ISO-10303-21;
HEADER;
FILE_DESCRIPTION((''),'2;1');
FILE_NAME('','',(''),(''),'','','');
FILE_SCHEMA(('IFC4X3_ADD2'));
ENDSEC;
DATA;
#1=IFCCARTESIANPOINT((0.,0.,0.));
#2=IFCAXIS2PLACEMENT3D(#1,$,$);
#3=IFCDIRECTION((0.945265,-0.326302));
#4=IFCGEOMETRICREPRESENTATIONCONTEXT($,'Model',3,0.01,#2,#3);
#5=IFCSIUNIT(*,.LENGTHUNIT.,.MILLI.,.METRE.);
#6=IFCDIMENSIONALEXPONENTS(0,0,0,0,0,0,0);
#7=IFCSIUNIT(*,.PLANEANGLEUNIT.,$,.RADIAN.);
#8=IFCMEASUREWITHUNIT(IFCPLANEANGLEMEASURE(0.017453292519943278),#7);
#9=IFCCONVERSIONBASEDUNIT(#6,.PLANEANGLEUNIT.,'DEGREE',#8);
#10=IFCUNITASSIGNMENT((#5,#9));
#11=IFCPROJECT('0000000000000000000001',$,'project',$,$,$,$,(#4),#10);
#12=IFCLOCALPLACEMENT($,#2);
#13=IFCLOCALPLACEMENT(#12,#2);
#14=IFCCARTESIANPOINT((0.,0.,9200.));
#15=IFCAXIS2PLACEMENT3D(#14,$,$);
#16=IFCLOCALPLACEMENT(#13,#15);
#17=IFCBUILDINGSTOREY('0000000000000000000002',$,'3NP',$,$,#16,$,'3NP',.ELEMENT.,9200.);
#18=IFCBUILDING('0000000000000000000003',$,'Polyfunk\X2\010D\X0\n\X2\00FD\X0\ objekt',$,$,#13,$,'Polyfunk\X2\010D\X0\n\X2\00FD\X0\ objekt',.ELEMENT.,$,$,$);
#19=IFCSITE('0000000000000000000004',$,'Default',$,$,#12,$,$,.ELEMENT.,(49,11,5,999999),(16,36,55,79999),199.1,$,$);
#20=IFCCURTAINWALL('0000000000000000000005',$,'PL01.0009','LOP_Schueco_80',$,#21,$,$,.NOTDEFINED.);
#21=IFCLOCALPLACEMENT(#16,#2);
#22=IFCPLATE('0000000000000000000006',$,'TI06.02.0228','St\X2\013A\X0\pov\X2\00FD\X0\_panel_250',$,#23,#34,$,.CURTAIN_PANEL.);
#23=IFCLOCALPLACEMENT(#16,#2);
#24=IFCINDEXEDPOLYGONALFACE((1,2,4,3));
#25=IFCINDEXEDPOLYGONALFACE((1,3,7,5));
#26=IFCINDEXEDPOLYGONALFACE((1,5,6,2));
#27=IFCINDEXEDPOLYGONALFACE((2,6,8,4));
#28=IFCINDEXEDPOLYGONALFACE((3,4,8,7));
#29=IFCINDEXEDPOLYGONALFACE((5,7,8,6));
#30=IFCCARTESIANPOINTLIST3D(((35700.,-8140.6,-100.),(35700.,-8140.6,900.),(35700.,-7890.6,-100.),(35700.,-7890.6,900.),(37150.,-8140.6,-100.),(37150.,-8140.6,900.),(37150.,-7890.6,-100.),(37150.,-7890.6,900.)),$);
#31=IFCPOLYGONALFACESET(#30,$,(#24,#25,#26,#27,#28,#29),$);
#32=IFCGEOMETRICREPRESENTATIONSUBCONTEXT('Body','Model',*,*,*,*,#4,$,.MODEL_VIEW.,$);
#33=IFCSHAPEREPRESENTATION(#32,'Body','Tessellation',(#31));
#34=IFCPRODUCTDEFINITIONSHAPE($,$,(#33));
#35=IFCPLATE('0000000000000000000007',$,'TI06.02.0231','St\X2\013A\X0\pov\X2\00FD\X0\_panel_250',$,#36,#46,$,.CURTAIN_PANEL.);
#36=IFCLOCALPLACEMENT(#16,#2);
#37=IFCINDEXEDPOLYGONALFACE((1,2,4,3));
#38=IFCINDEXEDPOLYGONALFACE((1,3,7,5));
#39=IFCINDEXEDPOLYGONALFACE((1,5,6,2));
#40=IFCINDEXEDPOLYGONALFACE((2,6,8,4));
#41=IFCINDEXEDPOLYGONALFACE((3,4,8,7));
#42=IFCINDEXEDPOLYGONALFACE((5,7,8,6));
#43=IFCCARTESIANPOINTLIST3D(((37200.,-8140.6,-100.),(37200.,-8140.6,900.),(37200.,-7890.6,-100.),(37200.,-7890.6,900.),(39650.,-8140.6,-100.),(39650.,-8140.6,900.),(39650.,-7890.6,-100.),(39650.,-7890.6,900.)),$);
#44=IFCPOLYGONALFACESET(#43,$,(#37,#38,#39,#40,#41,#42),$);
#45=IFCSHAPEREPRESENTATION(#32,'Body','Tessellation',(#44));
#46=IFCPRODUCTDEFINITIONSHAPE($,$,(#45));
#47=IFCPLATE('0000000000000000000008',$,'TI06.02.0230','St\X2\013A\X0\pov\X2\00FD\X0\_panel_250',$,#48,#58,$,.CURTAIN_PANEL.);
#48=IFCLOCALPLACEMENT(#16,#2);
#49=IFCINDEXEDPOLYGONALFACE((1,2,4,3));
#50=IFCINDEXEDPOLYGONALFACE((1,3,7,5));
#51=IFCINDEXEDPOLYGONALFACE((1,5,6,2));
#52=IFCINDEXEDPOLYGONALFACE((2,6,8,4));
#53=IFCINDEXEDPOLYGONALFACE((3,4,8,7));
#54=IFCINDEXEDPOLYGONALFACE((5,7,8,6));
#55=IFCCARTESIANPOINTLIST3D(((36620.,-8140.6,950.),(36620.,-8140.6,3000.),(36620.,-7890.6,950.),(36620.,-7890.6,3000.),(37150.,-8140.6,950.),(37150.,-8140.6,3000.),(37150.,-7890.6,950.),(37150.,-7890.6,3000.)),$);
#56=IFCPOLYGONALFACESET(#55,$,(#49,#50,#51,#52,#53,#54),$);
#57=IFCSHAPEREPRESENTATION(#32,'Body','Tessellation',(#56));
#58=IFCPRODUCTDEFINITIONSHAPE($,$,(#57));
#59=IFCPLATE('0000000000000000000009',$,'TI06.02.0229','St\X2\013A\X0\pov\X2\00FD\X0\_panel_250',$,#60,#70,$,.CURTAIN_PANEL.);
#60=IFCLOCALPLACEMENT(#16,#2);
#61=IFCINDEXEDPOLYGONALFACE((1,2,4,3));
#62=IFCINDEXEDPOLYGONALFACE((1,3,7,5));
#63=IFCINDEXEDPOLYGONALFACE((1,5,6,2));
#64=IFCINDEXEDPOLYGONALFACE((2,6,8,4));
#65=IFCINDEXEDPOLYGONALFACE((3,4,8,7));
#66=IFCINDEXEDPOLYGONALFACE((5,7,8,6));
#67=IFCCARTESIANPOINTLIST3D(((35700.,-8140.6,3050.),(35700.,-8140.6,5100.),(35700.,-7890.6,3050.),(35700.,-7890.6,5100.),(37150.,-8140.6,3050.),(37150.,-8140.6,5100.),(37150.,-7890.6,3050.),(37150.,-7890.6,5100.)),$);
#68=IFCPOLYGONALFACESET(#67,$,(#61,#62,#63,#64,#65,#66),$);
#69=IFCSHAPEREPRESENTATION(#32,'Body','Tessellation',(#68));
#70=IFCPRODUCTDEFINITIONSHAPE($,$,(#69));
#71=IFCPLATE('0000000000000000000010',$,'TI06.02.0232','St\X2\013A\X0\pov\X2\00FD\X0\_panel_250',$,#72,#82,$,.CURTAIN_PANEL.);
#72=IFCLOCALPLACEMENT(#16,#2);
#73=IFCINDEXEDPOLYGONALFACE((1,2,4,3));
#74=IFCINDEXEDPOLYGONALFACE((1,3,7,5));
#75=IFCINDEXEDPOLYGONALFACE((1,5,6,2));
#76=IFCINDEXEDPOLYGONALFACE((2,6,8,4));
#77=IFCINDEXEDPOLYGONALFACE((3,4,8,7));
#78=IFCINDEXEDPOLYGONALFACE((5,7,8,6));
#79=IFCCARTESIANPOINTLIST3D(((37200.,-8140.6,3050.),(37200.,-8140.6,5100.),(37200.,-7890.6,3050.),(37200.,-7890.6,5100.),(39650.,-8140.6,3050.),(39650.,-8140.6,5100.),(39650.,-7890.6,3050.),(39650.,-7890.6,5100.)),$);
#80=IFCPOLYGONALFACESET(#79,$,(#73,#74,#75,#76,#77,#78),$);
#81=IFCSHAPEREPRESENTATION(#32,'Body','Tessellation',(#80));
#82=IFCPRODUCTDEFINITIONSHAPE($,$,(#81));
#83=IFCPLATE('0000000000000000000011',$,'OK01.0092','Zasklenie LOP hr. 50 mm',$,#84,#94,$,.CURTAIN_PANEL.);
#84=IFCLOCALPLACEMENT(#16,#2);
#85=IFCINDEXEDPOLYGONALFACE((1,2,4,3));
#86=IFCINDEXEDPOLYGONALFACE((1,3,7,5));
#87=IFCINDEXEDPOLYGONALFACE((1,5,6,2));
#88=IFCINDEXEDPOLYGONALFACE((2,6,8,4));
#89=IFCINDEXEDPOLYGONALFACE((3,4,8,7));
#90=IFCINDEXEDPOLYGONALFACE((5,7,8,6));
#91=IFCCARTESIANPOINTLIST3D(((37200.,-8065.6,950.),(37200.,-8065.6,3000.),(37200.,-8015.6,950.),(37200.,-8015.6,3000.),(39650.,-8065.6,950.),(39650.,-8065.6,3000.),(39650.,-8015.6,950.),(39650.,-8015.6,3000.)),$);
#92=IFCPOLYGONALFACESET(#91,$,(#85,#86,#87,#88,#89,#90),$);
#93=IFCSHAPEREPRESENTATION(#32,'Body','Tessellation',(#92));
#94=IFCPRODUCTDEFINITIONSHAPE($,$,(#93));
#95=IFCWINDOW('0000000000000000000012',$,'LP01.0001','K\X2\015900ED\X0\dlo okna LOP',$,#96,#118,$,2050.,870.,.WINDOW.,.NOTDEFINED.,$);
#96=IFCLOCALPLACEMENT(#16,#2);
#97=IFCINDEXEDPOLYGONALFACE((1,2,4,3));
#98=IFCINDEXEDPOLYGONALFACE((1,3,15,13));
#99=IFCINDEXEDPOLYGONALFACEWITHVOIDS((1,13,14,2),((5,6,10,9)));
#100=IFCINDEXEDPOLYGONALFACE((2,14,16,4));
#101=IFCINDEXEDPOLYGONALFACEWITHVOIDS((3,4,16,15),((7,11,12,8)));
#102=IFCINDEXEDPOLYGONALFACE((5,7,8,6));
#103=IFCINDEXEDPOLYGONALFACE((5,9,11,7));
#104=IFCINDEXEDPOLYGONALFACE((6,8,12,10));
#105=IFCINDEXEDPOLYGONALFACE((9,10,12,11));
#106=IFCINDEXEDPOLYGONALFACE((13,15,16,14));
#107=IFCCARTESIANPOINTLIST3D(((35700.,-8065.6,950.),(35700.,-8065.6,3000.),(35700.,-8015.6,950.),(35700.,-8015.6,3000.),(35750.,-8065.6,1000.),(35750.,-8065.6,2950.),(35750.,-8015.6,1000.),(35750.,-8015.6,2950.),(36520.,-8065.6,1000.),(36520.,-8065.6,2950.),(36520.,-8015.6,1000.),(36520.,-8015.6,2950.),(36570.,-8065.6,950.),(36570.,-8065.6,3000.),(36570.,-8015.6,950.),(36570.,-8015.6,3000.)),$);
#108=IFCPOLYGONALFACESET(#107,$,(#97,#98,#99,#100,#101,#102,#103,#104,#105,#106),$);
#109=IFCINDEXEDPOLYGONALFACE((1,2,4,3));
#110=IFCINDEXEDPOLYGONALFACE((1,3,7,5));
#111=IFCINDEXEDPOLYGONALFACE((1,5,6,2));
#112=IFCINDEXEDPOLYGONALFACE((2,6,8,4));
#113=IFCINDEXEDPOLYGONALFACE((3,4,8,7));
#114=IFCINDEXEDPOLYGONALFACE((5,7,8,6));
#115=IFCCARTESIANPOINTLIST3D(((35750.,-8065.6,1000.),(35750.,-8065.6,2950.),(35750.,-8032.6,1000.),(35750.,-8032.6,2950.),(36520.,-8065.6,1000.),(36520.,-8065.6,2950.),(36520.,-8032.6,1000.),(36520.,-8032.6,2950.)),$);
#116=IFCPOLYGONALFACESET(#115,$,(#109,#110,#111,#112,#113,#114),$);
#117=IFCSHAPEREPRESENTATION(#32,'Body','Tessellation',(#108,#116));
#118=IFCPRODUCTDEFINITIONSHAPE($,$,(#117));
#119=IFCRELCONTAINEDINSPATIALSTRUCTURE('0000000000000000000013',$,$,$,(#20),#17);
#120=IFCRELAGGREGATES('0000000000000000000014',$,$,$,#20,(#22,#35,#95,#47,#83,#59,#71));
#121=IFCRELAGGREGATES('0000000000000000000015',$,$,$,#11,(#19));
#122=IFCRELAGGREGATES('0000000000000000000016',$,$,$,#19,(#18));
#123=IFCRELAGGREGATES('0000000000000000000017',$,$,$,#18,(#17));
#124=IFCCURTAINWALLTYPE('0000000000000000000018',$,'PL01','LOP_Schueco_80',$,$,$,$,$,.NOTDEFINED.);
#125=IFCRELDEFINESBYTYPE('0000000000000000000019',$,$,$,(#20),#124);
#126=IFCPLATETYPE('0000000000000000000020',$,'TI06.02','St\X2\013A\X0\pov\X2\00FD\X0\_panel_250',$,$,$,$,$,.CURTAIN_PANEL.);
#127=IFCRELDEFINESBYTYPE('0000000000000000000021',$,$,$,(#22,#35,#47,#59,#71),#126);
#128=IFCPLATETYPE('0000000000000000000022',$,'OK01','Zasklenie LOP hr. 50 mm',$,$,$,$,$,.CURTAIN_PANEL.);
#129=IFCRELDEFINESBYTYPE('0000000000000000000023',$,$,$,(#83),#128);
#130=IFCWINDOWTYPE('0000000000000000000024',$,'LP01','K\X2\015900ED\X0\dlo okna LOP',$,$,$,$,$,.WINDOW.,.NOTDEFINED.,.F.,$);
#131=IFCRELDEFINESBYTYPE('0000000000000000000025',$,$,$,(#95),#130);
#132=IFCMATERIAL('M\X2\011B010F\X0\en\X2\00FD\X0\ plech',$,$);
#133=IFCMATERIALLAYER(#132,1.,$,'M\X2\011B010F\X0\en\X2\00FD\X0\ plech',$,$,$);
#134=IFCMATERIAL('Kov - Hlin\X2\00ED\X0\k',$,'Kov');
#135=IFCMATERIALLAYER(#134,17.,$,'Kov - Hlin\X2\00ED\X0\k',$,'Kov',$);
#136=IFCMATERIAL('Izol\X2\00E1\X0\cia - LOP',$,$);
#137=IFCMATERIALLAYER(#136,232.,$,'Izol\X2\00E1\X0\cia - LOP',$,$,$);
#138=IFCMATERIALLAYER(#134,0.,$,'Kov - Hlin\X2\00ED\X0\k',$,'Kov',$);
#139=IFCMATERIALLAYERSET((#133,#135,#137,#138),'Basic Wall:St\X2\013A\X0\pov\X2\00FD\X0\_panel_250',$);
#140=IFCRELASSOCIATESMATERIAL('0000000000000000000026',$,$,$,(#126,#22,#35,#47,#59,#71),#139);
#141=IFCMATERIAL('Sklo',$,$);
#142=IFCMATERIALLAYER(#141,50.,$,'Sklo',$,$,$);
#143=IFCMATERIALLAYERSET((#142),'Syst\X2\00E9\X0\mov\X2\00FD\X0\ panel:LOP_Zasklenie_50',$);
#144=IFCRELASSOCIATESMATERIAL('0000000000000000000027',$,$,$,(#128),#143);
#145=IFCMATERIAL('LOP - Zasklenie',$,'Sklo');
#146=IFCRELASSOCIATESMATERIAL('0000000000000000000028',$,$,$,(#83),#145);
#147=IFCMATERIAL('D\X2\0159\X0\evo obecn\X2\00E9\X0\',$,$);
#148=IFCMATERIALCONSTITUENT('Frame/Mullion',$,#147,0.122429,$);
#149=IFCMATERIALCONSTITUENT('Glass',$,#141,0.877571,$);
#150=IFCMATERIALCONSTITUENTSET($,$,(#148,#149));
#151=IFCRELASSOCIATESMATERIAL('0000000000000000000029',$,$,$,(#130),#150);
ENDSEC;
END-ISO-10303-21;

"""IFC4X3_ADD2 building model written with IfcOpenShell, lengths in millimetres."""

from ifc_helpers import new_model, entity, si_unit, converted_unit, direction, frame, frame_2d, origin, origin_2d_with_axis, place, context, subcontext, project, spatial, polyline, rectangle, outline, extrude, source, transform, mapped, material, layer, layer_set, layer_usage, constituent, constituent_set, type_object, type_shapes, element, aggregate, save


model = new_model("IFC4X3_ADD2")

# Units and contexts
model_context = context("Model", 3, precision=0.01, world=origin(), true_north=direction((0.945265, -0.326302)))
body_context = subcontext(model_context, "Body", "Model", "MODEL_VIEW")
ifc_project = project(units=[si_unit("LENGTHUNIT", "METRE", prefix="MILLI"), converted_unit("PLANEANGLEUNIT", "DEGREE", entity("IfcPlaneAngleMeasure", 0.017453292519943278), si_unit("PLANEANGLEUNIT", "RADIAN"), dimensions=[0, 0, 0, 0, 0, 0, 0])], contexts=[model_context])

# Site, building, storey
site_placement = place(None, origin())
site = spatial("IfcSite", under=ifc_project, at=site_placement, Name="Default", CompositionType="ELEMENT", RefLatitude=(49, 11, 5, 999999), RefLongitude=(16, 36, 55, 79999), RefElevation=199.1)
building_placement = place(site_placement, origin())
building = spatial("IfcBuilding", under=site, at=building_placement, Name="Polyfunkčný objekt", LongName="Polyfunkčný objekt", CompositionType="ELEMENT")
storey_placement = place(building_placement, frame((0.0, 0.0, 9200.0)))
storey = spatial("IfcBuildingStorey", under=building, at=storey_placement, Name="3NP", LongName="3NP", CompositionType="ELEMENT", Elevation=9200.0)

# Curtain wall, plates, window
curtain_wall_type = type_object("IfcCurtainWallType", Name="PL01", Description="LOP_Schueco_80", PredefinedType="NOTDEFINED")
curtain_wall_placement = place(storey_placement, frame((0.0, 0.0, -9200.0)))
curtain_wall = element("IfcCurtainWall", 1, at=curtain_wall_placement, inside=storey, type_object=curtain_wall_type, Name="PL01.0009", Description="LOP_Schueco_80", PredefinedType="NOTDEFINED")
ifc_material_1 = material(Name="Měďený plech")
ifc_layer_1 = layer(ifc_material_1, 1.0, Name="Měďený plech")
ifc_material_2 = material(Name="Kov - Hliník", Category="Kov")
ifc_layer_2 = layer(ifc_material_2, 17.0, Name="Kov - Hliník", Category="Kov")
ifc_material_3 = material(Name="Izolácia - LOP")
ifc_layer_3 = layer(ifc_material_3, 232.0, Name="Izolácia - LOP")
ifc_layer_4 = layer(ifc_material_2, 0.0, Name="Kov - Hliník", Category="Kov")
ifc_layer_set_1 = layer_set([ifc_layer_1, ifc_layer_2, ifc_layer_3, ifc_layer_4], Name="Basic Wall:Stĺpový_panel_250")
ifc_layer_usage_1 = layer_usage(ifc_layer_set_1, "AXIS2", "POSITIVE", -125.0)
plate_type_1 = type_object("IfcPlateType", Name="TI06.02", Description="Stĺpový_panel_250", PredefinedType="CURTAIN_PANEL", material=ifc_layer_set_1)
plate_1_placement = place(storey_placement, frame((35700.0, -8015.6, -100.0)))
plate_1 = element("IfcPlate", 2, at=plate_1_placement, type_object=plate_type_1, material=ifc_layer_usage_1, Name="TI06.02.0228", Description="Stĺpový_panel_250", PredefinedType="CURTAIN_PANEL", context=body_context, shape_type="SweptSolid", body=[
    extrude(rectangle(XDim=250.0, YDim=1450.0, at=frame_2d((0.0, 0.0), x_axis=(1.0, 0.0))), frame((725.0, 0.0, 0.0), z_axis=(0.0, 0.0, 1.0), x_axis=(0.0, 1.0, 0.0)), (0.0, 0.0, 1.0), 1000.0),
])
ifc_layer_usage_2 = layer_usage(ifc_layer_set_1, "AXIS2", "POSITIVE", -125.0)
plate_2_placement = place(storey_placement, frame((37200.0, -8015.6, -100.0)))
plate_2 = element("IfcPlate", 3, at=plate_2_placement, type_object=plate_type_1, material=ifc_layer_usage_2, Name="TI06.02.0231", Description="Stĺpový_panel_250", PredefinedType="CURTAIN_PANEL", context=body_context, shape_type="SweptSolid", body=[
    extrude(rectangle(XDim=250.0, YDim=2450.0, at=frame_2d((0.0, 0.0), x_axis=(1.0, 0.0))), frame((1225.0, 0.0, 0.0), z_axis=(0.0, 0.0, 1.0), x_axis=(0.0, 1.0, 0.0)), (0.0, 0.0, 1.0), 1000.0),
])
ifc_layer_usage_3 = layer_usage(ifc_layer_set_1, "AXIS2", "POSITIVE", -125.0)
plate_3_placement = place(storey_placement, frame((36620.0, -8015.6, 950.0)))
plate_3 = element("IfcPlate", 4, at=plate_3_placement, type_object=plate_type_1, material=ifc_layer_usage_3, Name="TI06.02.0230", Description="Stĺpový_panel_250", PredefinedType="CURTAIN_PANEL", context=body_context, shape_type="SweptSolid", body=[
    extrude(rectangle(XDim=250.0, YDim=530.0, at=frame_2d((0.0, 0.0), x_axis=(1.0, 0.0))), frame((265.0, 0.0, 0.0), z_axis=(0.0, 0.0, 1.0), x_axis=(0.0, 1.0, 0.0)), (0.0, 0.0, 1.0), 2050.0),
])
ifc_layer_usage_4 = layer_usage(ifc_layer_set_1, "AXIS2", "POSITIVE", -125.0)
plate_4_placement = place(storey_placement, frame((35700.0, -8015.6, 3050.0)))
plate_4 = element("IfcPlate", 5, at=plate_4_placement, type_object=plate_type_1, material=ifc_layer_usage_4, Name="TI06.02.0229", Description="Stĺpový_panel_250", PredefinedType="CURTAIN_PANEL", context=body_context, shape_type="SweptSolid", body=[
    extrude(rectangle(XDim=250.0, YDim=1450.0, at=frame_2d((0.0, 0.0), x_axis=(1.0, 0.0))), frame((725.0, 0.0, 0.0), z_axis=(0.0, 0.0, 1.0), x_axis=(0.0, 1.0, 0.0)), (0.0, 0.0, 1.0), 2050.0),
])
ifc_layer_usage_5 = layer_usage(ifc_layer_set_1, "AXIS2", "POSITIVE", -125.0)
plate_5_placement = place(storey_placement, frame((37200.0, -8015.6, 3050.0)))
plate_5 = element("IfcPlate", 6, at=plate_5_placement, type_object=plate_type_1, material=ifc_layer_usage_5, Name="TI06.02.0232", Description="Stĺpový_panel_250", PredefinedType="CURTAIN_PANEL", context=body_context, shape_type="SweptSolid", body=[
    extrude(rectangle(XDim=250.0, YDim=2450.0, at=frame_2d((0.0, 0.0), x_axis=(1.0, 0.0))), frame((1225.0, 0.0, 0.0), z_axis=(0.0, 0.0, 1.0), x_axis=(0.0, 1.0, 0.0)), (0.0, 0.0, 1.0), 2050.0),
])
ifc_material_4 = material(Name="LOP - Zasklenie", Category="Sklo")
ifc_material_5 = material(Name="Sklo")
ifc_layer_5 = layer(ifc_material_5, 50.0, Name="Sklo")
ifc_layer_set_2 = layer_set([ifc_layer_5], Name="Systémový panel:LOP_Zasklenie_50")
plate_type_2 = type_object("IfcPlateType", Name="OK01", Description="Zasklenie LOP hr. 50 mm", PredefinedType="CURTAIN_PANEL", material=ifc_layer_set_2)
shared_shape_1 = source(origin(), body_context, "Body", "SweptSolid", [
    extrude(rectangle(XDim=50.0, YDim=2450.0, at=origin_2d_with_axis()), frame((0.0, -25.0, 0.0), z_axis=(0.0, 0.0, 1.0), x_axis=(0.0, 1.0, 0.0)), (0.0, 0.0, 1.0), 2050.0),
])
type_shapes(plate_type_2, [shared_shape_1])
plate_6_placement = place(curtain_wall_placement, frame((38425.0, -8015.6, 10150.0)))
plate_6 = element("IfcPlate", 7, at=plate_6_placement, type_object=plate_type_2, material=ifc_material_4, Name="OK01.0092", Description="Zasklenie LOP hr. 50 mm", PredefinedType="CURTAIN_PANEL", context=body_context, shape_type="MappedRepresentation", body=[
    mapped(shared_shape_1, transform((0.0, 0.0, 0.0), scale=1.0)),
])
ifc_material_6 = material(Name="Dřevo obecné")
ifc_constituent_1 = constituent(ifc_material_6, Name="Frame/Mullion", fraction=0.122429)
ifc_constituent_2 = constituent(ifc_material_5, Name="Glass", fraction=0.877571)
ifc_constituent_set = constituent_set(constituents=[ifc_constituent_1, ifc_constituent_2])
window_type = type_object("IfcWindowType", Name="LP01", Description="Křídlo okna LOP", ParameterTakesPrecedence=False, PartitioningType="NOTDEFINED", PredefinedType="WINDOW", material=ifc_constituent_set)
shared_shape_2 = source(origin(), body_context, "Body", "SweptSolid", [
    extrude(outline(polyline([(-1025.0, -435.0), (1025.0, -435.0), (1025.0, 435.0), (-1025.0, 435.0), (-1025.0, -435.0)]), holes=[polyline([(-975.0, -385.0), (-975.0, 385.0), (975.0, 385.0), (975.0, -385.0), (-975.0, -385.0)])]), frame((0.0, 50.0, 1025.0), z_axis=(0.0, -1.0, 0.0), x_axis=(0.0, 0.0, -1.0)), (0.0, 0.0, 1.0), 50.0),
    extrude(rectangle(XDim=770.0, YDim=33.0, at=frame_2d((0.0, 0.0), x_axis=(1.0, 0.0))), frame((0.0, 33.5, 50.0), z_axis=(0.0, 0.0, 1.0), x_axis=(-1.0, 0.0, 0.0)), (0.0, 0.0, 1.0), 1950.0),
])
type_shapes(window_type, [shared_shape_2])
window_placement = place(curtain_wall_placement, frame((36135.0, -8015.6, 10150.0), z_axis=(0.0, 0.0, 1.0), x_axis=(-1.0, 0.0, 0.0)))
window = element("IfcWindow", 8, at=window_placement, type_object=window_type, Name="LP01.0001", Description="Křídlo okna LOP", OverallHeight=2050.0, OverallWidth=870.0, PartitioningType="NOTDEFINED", PredefinedType="WINDOW", context=body_context, shape_type="MappedRepresentation", body=[
    mapped(shared_shape_2, transform((0.0, 0.0, 0.0), scale=1.0)),
])
aggregate(curtain_wall, [plate_1, plate_2, window, plate_3, plate_6, plate_4, plate_5])

save(model, "model.ifc")
